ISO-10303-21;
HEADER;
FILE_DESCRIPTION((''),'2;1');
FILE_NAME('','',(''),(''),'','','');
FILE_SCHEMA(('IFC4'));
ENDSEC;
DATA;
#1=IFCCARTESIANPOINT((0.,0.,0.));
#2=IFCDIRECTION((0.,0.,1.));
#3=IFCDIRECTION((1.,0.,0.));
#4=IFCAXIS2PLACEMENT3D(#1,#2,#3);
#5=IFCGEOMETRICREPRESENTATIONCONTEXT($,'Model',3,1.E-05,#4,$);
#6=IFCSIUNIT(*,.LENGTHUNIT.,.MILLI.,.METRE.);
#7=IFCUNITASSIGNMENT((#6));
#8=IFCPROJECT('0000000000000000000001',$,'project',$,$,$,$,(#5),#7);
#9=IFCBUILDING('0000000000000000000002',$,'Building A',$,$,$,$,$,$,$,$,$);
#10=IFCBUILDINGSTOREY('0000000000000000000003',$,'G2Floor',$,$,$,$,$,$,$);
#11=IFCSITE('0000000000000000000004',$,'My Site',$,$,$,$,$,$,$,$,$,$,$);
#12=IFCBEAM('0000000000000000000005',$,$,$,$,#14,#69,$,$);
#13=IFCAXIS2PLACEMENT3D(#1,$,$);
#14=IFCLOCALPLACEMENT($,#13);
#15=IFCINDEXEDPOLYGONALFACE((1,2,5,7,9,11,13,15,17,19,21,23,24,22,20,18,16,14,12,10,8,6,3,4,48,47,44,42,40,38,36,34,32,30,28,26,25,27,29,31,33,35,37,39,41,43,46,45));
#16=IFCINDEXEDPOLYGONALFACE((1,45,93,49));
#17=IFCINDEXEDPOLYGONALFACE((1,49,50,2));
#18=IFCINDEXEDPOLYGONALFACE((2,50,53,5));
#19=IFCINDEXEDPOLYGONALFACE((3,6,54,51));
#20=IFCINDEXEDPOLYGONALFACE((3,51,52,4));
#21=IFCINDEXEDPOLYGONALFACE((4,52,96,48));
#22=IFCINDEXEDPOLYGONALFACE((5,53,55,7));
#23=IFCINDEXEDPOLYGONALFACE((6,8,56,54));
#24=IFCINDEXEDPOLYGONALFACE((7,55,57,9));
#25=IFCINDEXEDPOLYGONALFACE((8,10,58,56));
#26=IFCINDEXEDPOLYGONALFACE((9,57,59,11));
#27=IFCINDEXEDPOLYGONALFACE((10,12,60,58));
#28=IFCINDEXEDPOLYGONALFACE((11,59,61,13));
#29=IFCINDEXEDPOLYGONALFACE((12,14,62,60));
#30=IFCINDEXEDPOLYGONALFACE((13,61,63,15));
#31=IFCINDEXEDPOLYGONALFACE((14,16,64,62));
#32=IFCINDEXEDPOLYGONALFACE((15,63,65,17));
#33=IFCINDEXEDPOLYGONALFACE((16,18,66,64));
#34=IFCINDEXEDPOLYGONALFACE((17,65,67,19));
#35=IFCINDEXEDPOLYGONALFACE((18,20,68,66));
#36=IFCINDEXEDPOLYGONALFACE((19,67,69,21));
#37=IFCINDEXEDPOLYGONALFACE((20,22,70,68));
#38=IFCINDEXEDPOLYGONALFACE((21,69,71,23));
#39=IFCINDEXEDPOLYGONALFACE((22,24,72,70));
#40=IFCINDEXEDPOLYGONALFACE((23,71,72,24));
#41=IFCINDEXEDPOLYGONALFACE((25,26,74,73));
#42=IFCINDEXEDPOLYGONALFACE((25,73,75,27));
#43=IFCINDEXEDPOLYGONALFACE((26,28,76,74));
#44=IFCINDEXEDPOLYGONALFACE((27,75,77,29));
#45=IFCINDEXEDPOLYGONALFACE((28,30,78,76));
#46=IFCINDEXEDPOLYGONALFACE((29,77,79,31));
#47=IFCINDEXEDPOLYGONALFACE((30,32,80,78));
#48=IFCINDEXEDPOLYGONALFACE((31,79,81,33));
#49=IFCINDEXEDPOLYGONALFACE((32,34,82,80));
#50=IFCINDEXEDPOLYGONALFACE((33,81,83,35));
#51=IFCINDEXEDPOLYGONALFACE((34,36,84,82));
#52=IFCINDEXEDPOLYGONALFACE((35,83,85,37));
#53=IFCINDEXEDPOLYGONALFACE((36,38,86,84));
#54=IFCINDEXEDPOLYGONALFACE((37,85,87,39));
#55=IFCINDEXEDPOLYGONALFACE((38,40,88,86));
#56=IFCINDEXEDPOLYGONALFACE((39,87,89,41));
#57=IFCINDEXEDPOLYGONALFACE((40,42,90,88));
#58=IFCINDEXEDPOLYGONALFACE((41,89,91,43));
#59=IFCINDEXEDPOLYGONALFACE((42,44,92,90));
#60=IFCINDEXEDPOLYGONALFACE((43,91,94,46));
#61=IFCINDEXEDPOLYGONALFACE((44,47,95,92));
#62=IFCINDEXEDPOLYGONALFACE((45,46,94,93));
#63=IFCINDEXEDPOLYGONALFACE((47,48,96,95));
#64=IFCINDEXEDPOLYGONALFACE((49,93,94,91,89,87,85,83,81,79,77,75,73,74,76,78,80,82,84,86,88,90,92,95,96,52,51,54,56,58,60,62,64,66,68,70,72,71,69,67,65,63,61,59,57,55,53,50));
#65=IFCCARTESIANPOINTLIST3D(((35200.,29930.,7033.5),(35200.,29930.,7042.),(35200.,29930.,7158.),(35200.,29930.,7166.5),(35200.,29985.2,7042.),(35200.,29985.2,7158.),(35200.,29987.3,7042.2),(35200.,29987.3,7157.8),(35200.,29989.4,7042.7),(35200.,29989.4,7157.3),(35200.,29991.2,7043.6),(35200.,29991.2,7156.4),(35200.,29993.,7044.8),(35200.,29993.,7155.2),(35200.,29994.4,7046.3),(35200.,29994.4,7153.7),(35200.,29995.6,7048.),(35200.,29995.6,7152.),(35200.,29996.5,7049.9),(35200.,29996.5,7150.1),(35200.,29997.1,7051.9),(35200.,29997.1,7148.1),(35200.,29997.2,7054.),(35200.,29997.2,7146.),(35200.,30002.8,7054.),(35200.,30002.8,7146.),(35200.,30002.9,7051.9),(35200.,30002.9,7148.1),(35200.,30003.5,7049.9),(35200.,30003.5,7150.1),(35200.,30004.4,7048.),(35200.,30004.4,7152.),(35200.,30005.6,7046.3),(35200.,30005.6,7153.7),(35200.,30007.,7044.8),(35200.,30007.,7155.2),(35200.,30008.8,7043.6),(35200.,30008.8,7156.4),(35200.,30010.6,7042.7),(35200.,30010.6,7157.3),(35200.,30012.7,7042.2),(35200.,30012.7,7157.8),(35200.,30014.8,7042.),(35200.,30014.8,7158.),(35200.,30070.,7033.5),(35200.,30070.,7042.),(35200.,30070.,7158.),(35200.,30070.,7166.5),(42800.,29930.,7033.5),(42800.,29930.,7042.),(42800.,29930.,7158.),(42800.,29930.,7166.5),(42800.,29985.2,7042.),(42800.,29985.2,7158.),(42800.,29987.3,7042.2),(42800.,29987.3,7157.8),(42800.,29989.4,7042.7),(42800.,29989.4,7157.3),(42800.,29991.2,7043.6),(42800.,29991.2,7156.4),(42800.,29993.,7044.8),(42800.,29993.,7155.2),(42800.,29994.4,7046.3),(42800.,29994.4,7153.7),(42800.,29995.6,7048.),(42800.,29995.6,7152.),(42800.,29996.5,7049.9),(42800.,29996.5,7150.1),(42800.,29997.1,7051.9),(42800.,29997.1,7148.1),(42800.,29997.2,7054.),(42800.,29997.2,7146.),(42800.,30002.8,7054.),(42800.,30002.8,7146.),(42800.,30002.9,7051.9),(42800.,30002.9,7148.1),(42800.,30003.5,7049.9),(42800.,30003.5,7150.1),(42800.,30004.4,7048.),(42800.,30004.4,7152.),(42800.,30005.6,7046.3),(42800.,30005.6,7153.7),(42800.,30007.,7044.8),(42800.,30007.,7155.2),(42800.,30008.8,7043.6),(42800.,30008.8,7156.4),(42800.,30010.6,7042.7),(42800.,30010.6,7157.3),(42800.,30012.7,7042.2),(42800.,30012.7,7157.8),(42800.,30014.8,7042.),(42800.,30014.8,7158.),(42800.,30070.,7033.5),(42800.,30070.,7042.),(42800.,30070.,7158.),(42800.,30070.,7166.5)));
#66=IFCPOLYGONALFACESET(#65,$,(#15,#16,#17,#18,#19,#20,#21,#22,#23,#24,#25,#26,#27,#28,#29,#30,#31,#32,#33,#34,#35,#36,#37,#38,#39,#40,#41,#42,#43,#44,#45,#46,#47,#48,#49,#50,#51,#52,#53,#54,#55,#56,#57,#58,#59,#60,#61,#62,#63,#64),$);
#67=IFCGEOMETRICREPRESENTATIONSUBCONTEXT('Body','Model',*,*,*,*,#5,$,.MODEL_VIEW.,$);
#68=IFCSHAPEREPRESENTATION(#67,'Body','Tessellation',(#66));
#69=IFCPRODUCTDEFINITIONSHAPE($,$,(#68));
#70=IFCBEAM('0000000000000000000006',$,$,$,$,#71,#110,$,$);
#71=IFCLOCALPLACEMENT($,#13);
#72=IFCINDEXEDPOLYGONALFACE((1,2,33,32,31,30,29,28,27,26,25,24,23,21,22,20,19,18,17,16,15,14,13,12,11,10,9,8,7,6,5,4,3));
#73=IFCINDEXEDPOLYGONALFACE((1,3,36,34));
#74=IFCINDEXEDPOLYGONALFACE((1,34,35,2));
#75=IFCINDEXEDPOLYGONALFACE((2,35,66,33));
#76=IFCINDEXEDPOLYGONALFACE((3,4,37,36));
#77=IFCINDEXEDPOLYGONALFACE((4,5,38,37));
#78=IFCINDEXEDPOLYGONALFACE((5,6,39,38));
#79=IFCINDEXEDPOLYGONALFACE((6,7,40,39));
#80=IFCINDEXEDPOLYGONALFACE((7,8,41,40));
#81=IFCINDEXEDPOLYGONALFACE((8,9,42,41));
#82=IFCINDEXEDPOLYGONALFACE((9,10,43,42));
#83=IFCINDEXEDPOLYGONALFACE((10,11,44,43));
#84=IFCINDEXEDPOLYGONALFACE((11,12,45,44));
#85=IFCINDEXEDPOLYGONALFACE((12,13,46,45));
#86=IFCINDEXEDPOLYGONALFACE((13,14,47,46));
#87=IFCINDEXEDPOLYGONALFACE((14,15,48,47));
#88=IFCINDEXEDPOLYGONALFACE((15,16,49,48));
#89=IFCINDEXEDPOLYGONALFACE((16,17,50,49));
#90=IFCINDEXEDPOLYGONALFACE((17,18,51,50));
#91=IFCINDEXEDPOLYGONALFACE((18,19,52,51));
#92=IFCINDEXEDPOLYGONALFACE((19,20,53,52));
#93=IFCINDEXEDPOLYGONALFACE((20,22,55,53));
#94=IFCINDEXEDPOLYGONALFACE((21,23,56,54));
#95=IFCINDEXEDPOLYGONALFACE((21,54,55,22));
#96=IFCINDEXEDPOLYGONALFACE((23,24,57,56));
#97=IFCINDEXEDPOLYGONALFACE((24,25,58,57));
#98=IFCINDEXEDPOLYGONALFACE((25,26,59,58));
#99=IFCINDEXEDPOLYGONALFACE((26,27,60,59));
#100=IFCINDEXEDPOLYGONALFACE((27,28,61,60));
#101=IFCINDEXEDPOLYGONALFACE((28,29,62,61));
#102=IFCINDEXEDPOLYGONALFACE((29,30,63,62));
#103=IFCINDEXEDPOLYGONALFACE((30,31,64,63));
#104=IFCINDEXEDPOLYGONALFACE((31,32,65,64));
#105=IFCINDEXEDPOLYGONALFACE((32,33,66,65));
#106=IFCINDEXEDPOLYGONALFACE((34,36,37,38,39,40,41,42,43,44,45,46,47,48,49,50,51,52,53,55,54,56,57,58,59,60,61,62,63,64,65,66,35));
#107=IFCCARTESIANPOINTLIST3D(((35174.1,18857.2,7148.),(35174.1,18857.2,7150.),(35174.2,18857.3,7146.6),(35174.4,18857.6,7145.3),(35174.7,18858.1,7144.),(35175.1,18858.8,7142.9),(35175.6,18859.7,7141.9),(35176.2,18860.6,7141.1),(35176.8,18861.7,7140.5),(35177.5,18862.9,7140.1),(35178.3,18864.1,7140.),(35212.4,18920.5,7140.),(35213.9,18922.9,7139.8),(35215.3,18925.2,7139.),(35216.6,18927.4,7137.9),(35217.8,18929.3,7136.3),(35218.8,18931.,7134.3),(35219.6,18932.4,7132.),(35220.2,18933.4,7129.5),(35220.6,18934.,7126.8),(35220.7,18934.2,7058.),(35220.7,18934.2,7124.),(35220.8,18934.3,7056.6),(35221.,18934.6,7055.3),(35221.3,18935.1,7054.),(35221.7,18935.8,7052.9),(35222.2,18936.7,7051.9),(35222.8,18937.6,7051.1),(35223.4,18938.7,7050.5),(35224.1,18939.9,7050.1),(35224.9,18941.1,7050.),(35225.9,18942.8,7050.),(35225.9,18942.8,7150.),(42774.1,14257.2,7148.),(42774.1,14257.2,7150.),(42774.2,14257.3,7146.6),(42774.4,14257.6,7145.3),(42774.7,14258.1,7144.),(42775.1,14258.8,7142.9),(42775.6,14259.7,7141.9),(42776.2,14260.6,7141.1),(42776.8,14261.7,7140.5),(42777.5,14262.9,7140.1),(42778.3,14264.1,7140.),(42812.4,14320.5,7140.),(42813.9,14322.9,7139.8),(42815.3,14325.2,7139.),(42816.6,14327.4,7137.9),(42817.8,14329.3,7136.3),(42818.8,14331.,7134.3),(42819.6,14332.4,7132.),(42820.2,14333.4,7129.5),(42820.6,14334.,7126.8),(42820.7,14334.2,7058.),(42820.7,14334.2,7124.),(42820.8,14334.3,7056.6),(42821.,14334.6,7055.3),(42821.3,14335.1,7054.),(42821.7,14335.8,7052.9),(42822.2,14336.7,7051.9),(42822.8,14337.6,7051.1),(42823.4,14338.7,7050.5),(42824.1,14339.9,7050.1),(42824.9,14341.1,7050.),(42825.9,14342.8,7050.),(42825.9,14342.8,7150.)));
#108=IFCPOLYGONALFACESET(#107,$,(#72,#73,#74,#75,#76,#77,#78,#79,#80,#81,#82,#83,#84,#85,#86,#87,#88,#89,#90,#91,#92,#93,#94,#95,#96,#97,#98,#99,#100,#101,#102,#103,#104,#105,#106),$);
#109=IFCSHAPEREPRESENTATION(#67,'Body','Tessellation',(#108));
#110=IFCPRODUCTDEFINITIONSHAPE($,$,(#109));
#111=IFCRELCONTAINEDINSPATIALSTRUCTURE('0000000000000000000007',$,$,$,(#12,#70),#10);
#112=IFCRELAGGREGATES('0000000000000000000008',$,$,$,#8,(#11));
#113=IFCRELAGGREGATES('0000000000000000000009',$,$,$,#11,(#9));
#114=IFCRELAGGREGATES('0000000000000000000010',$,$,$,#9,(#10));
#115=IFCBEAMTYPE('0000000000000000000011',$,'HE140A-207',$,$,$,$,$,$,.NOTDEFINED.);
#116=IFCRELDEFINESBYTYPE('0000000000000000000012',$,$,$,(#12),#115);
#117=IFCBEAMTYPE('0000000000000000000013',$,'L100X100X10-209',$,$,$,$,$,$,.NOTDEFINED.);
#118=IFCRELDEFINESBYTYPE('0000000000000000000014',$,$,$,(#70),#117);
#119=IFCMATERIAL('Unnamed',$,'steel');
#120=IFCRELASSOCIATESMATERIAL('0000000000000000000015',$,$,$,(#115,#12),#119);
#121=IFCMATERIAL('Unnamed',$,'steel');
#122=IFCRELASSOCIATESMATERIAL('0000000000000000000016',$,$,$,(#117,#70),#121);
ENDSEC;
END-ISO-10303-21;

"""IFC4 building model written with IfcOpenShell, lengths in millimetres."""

from ifc_helpers import new_model, si_unit, frame, origin_with_axes, place, context, subcontext, project, spatial, polyline, outline, extrude, material, material_profile, profile_set, profile_usage, type_object, element, save


model = new_model("IFC4")

# Units and contexts
model_context = context("Model", 3, precision=1e-05, world=origin_with_axes())
body_context = subcontext(model_context, "Body", "Model", "MODEL_VIEW")
ifc_project = project(units=[si_unit("LENGTHUNIT", "METRE", prefix="MILLI")], contexts=[model_context])

# Site, building, storey
site = spatial("IfcSite", under=ifc_project, Name="My Site")
building = spatial("IfcBuilding", under=site, Name="Building A")
storey = spatial("IfcBuildingStorey", under=building, Name="G2Floor")

# Beams
ifc_material_1 = material(Name="Unnamed", Category="steel")
ifc_material_profile_1 = material_profile(ifc_material_1, outline(polyline([(70.0, -66.5), (70.0, -58.0), (70.0, -58.0), (14.8, -58.0), (14.8, -58.0), (12.7, -57.8), (12.7, -57.8), (10.6, -57.3), (10.6, -57.3), (8.8, -56.4), (8.8, -56.4), (7.0, -55.2), (7.0, -55.2), (5.6, -53.7), (5.6, -53.7), (4.4, -52.0), (4.4, -52.0), (3.5, -50.1), (3.5, -50.1), (2.9, -48.1), (2.9, -48.1), (2.8, -46.0), (2.8, -46.0), (2.8, 46.0), (2.8, 46.0), (2.9, 48.1), (2.9, 48.1), (3.5, 50.1), (3.5, 50.1), (4.4, 52.0), (4.4, 52.0), (5.6, 53.7), (5.6, 53.7), (7.0, 55.2), (7.0, 55.2), (8.8, 56.4), (8.8, 56.4), (10.6, 57.3), (10.6, 57.3), (12.7, 57.8), (12.7, 57.8), (14.8, 58.0), (14.8, 58.0), (70.0, 58.0), (70.0, 58.0), (70.0, 66.5), (70.0, 66.5), (-70.0, 66.5), (-70.0, 66.5), (-70.0, 58.0), (-70.0, 58.0), (-14.8, 58.0), (-14.8, 58.0), (-12.7, 57.8), (-12.7, 57.8), (-10.6, 57.3), (-10.6, 57.3), (-8.8, 56.4), (-8.8, 56.4), (-7.0, 55.2), (-7.0, 55.2), (-5.6, 53.7), (-5.6, 53.7), (-4.4, 52.0), (-4.4, 52.0), (-3.5, 50.1), (-3.5, 50.1), (-2.9, 48.1), (-2.9, 48.1), (-2.8, 46.0), (-2.8, 46.0), (-2.8, -46.0), (-2.8, -46.0), (-2.9, -48.1), (-2.9, -48.1), (-3.5, -50.1), (-3.5, -50.1), (-4.4, -52.0), (-4.4, -52.0), (-5.6, -53.7), (-5.6, -53.7), (-7.0, -55.2), (-7.0, -55.2), (-8.8, -56.4), (-8.8, -56.4), (-10.6, -57.3), (-10.6, -57.3), (-12.7, -57.8), (-12.7, -57.8), (-14.8, -58.0), (-14.8, -58.0), (-70.0, -58.0), (-70.0, -58.0), (-70.0, -66.5), (-70.0, -66.5), (70.0, -66.5)])))
ifc_profile_set_1 = profile_set([ifc_material_profile_1], Name="HE140A-207")
ifc_profile_usage_1 = profile_usage(ifc_profile_set_1)
beam_type_1 = type_object("IfcBeamType", Name="HE140A-207", PredefinedType="NOTDEFINED", material=ifc_profile_set_1)
beam_1_placement = place(None, frame((35200.0, 30000.0, 7100.0), z_axis=(1.0, 0.0, 0.0), x_axis=(0.0, -1.0, 0.0)))
element("IfcBeam", 1, at=beam_1_placement, inside=storey, type_object=beam_type_1, material=ifc_profile_usage_1, context=body_context, shape_type="SweptSolid", body=[
    extrude(outline(polyline([(70.0, -66.5), (70.0, -58.0), (70.0, -58.0), (14.8, -58.0), (14.8, -58.0), (12.7, -57.8), (12.7, -57.8), (10.6, -57.3), (10.6, -57.3), (8.8, -56.4), (8.8, -56.4), (7.0, -55.2), (7.0, -55.2), (5.6, -53.7), (5.6, -53.7), (4.4, -52.0), (4.4, -52.0), (3.5, -50.1), (3.5, -50.1), (2.9, -48.1), (2.9, -48.1), (2.8, -46.0), (2.8, -46.0), (2.8, 46.0), (2.8, 46.0), (2.9, 48.1), (2.9, 48.1), (3.5, 50.1), (3.5, 50.1), (4.4, 52.0), (4.4, 52.0), (5.6, 53.7), (5.6, 53.7), (7.0, 55.2), (7.0, 55.2), (8.8, 56.4), (8.8, 56.4), (10.6, 57.3), (10.6, 57.3), (12.7, 57.8), (12.7, 57.8), (14.8, 58.0), (14.8, 58.0), (70.0, 58.0), (70.0, 58.0), (70.0, 66.5), (70.0, 66.5), (-70.0, 66.5), (-70.0, 66.5), (-70.0, 58.0), (-70.0, 58.0), (-14.8, 58.0), (-14.8, 58.0), (-12.7, 57.8), (-12.7, 57.8), (-10.6, 57.3), (-10.6, 57.3), (-8.8, 56.4), (-8.8, 56.4), (-7.0, 55.2), (-7.0, 55.2), (-5.6, 53.7), (-5.6, 53.7), (-4.4, 52.0), (-4.4, 52.0), (-3.5, 50.1), (-3.5, 50.1), (-2.9, 48.1), (-2.9, 48.1), (-2.8, 46.0), (-2.8, 46.0), (-2.8, -46.0), (-2.8, -46.0), (-2.9, -48.1), (-2.9, -48.1), (-3.5, -50.1), (-3.5, -50.1), (-4.4, -52.0), (-4.4, -52.0), (-5.6, -53.7), (-5.6, -53.7), (-7.0, -55.2), (-7.0, -55.2), (-8.8, -56.4), (-8.8, -56.4), (-10.6, -57.3), (-10.6, -57.3), (-12.7, -57.8), (-12.7, -57.8), (-14.8, -58.0), (-14.8, -58.0), (-70.0, -58.0), (-70.0, -58.0), (-70.0, -66.5), (-70.0, -66.5), (70.0, -66.5)])), origin_with_axes(), (0.0, 0.0, 1.0), 7600.0),
])
ifc_material_2 = material(Name="Unnamed", Category="steel")
ifc_material_profile_2 = material_profile(ifc_material_2, outline(polyline([(-50.0, -50.0), (50.0, -50.0), (50.0, -50.0), (50.0, -48.0), (50.0, -48.0), (49.9, -46.6), (49.9, -46.6), (49.5, -45.3), (49.5, -45.3), (48.9, -44.0), (48.9, -44.0), (48.1, -42.9), (48.1, -42.9), (47.1, -41.9), (47.1, -41.9), (46.0, -41.1), (46.0, -41.1), (44.7, -40.5), (44.7, -40.5), (43.4, -40.1), (43.4, -40.1), (42.0, -40.0), (42.0, -40.0), (-24.0, -40.0), (-24.0, -40.0), (-26.8, -39.8), (-26.8, -39.8), (-29.5, -39.0), (-29.5, -39.0), (-32.0, -37.9), (-32.0, -37.9), (-34.3, -36.3), (-34.3, -36.3), (-36.3, -34.3), (-36.3, -34.3), (-37.9, -32.0), (-37.9, -32.0), (-39.0, -29.5), (-39.0, -29.5), (-39.8, -26.8), (-39.8, -26.8), (-40.0, -24.0), (-40.0, -24.0), (-40.0, 42.0), (-40.0, 42.0), (-40.1, 43.4), (-40.1, 43.4), (-40.5, 44.7), (-40.5, 44.7), (-41.1, 46.0), (-41.1, 46.0), (-41.9, 47.1), (-41.9, 47.1), (-42.9, 48.1), (-42.9, 48.1), (-44.0, 48.9), (-44.0, 48.9), (-45.3, 49.5), (-45.3, 49.5), (-46.6, 49.9), (-46.6, 49.9), (-48.0, 50.0), (-48.0, 50.0), (-50.0, 50.0), (-50.0, 50.0), (-50.0, -50.0)])))
ifc_profile_set_2 = profile_set([ifc_material_profile_2], Name="L100X100X10-209")
ifc_profile_usage_2 = profile_usage(ifc_profile_set_2)
beam_type_2 = type_object("IfcBeamType", Name="L100X100X10-209", PredefinedType="NOTDEFINED", material=ifc_profile_set_2)
beam_2_placement = place(None, frame((35200.0, 18900.0, 7100.0), z_axis=(0.8555, -0.517803, 0.0), x_axis=(-0.517803, -0.8555, 0.0)))
element("IfcBeam", 2, at=beam_2_placement, inside=storey, type_object=beam_type_2, material=ifc_profile_usage_2, context=body_context, shape_type="SweptSolid", body=[
    extrude(outline(polyline([(-50.0, -50.0), (50.0, -50.0), (50.0, -50.0), (50.0, -48.0), (50.0, -48.0), (49.9, -46.6), (49.9, -46.6), (49.5, -45.3), (49.5, -45.3), (48.9, -44.0), (48.9, -44.0), (48.1, -42.9), (48.1, -42.9), (47.1, -41.9), (47.1, -41.9), (46.0, -41.1), (46.0, -41.1), (44.7, -40.5), (44.7, -40.5), (43.4, -40.1), (43.4, -40.1), (42.0, -40.0), (42.0, -40.0), (-24.0, -40.0), (-24.0, -40.0), (-26.8, -39.8), (-26.8, -39.8), (-29.5, -39.0), (-29.5, -39.0), (-32.0, -37.9), (-32.0, -37.9), (-34.3, -36.3), (-34.3, -36.3), (-36.3, -34.3), (-36.3, -34.3), (-37.9, -32.0), (-37.9, -32.0), (-39.0, -29.5), (-39.0, -29.5), (-39.8, -26.8), (-39.8, -26.8), (-40.0, -24.0), (-40.0, -24.0), (-40.0, 42.0), (-40.0, 42.0), (-40.1, 43.4), (-40.1, 43.4), (-40.5, 44.7), (-40.5, 44.7), (-41.1, 46.0), (-41.1, 46.0), (-41.9, 47.1), (-41.9, 47.1), (-42.9, 48.1), (-42.9, 48.1), (-44.0, 48.9), (-44.0, 48.9), (-45.3, 49.5), (-45.3, 49.5), (-46.6, 49.9), (-46.6, 49.9), (-48.0, 50.0), (-48.0, 50.0), (-50.0, 50.0), (-50.0, 50.0), (-50.0, -50.0)])), origin_with_axes(), (0.0, 0.0, 1.0), 8883.7),
])

save(model, "model.ifc")
